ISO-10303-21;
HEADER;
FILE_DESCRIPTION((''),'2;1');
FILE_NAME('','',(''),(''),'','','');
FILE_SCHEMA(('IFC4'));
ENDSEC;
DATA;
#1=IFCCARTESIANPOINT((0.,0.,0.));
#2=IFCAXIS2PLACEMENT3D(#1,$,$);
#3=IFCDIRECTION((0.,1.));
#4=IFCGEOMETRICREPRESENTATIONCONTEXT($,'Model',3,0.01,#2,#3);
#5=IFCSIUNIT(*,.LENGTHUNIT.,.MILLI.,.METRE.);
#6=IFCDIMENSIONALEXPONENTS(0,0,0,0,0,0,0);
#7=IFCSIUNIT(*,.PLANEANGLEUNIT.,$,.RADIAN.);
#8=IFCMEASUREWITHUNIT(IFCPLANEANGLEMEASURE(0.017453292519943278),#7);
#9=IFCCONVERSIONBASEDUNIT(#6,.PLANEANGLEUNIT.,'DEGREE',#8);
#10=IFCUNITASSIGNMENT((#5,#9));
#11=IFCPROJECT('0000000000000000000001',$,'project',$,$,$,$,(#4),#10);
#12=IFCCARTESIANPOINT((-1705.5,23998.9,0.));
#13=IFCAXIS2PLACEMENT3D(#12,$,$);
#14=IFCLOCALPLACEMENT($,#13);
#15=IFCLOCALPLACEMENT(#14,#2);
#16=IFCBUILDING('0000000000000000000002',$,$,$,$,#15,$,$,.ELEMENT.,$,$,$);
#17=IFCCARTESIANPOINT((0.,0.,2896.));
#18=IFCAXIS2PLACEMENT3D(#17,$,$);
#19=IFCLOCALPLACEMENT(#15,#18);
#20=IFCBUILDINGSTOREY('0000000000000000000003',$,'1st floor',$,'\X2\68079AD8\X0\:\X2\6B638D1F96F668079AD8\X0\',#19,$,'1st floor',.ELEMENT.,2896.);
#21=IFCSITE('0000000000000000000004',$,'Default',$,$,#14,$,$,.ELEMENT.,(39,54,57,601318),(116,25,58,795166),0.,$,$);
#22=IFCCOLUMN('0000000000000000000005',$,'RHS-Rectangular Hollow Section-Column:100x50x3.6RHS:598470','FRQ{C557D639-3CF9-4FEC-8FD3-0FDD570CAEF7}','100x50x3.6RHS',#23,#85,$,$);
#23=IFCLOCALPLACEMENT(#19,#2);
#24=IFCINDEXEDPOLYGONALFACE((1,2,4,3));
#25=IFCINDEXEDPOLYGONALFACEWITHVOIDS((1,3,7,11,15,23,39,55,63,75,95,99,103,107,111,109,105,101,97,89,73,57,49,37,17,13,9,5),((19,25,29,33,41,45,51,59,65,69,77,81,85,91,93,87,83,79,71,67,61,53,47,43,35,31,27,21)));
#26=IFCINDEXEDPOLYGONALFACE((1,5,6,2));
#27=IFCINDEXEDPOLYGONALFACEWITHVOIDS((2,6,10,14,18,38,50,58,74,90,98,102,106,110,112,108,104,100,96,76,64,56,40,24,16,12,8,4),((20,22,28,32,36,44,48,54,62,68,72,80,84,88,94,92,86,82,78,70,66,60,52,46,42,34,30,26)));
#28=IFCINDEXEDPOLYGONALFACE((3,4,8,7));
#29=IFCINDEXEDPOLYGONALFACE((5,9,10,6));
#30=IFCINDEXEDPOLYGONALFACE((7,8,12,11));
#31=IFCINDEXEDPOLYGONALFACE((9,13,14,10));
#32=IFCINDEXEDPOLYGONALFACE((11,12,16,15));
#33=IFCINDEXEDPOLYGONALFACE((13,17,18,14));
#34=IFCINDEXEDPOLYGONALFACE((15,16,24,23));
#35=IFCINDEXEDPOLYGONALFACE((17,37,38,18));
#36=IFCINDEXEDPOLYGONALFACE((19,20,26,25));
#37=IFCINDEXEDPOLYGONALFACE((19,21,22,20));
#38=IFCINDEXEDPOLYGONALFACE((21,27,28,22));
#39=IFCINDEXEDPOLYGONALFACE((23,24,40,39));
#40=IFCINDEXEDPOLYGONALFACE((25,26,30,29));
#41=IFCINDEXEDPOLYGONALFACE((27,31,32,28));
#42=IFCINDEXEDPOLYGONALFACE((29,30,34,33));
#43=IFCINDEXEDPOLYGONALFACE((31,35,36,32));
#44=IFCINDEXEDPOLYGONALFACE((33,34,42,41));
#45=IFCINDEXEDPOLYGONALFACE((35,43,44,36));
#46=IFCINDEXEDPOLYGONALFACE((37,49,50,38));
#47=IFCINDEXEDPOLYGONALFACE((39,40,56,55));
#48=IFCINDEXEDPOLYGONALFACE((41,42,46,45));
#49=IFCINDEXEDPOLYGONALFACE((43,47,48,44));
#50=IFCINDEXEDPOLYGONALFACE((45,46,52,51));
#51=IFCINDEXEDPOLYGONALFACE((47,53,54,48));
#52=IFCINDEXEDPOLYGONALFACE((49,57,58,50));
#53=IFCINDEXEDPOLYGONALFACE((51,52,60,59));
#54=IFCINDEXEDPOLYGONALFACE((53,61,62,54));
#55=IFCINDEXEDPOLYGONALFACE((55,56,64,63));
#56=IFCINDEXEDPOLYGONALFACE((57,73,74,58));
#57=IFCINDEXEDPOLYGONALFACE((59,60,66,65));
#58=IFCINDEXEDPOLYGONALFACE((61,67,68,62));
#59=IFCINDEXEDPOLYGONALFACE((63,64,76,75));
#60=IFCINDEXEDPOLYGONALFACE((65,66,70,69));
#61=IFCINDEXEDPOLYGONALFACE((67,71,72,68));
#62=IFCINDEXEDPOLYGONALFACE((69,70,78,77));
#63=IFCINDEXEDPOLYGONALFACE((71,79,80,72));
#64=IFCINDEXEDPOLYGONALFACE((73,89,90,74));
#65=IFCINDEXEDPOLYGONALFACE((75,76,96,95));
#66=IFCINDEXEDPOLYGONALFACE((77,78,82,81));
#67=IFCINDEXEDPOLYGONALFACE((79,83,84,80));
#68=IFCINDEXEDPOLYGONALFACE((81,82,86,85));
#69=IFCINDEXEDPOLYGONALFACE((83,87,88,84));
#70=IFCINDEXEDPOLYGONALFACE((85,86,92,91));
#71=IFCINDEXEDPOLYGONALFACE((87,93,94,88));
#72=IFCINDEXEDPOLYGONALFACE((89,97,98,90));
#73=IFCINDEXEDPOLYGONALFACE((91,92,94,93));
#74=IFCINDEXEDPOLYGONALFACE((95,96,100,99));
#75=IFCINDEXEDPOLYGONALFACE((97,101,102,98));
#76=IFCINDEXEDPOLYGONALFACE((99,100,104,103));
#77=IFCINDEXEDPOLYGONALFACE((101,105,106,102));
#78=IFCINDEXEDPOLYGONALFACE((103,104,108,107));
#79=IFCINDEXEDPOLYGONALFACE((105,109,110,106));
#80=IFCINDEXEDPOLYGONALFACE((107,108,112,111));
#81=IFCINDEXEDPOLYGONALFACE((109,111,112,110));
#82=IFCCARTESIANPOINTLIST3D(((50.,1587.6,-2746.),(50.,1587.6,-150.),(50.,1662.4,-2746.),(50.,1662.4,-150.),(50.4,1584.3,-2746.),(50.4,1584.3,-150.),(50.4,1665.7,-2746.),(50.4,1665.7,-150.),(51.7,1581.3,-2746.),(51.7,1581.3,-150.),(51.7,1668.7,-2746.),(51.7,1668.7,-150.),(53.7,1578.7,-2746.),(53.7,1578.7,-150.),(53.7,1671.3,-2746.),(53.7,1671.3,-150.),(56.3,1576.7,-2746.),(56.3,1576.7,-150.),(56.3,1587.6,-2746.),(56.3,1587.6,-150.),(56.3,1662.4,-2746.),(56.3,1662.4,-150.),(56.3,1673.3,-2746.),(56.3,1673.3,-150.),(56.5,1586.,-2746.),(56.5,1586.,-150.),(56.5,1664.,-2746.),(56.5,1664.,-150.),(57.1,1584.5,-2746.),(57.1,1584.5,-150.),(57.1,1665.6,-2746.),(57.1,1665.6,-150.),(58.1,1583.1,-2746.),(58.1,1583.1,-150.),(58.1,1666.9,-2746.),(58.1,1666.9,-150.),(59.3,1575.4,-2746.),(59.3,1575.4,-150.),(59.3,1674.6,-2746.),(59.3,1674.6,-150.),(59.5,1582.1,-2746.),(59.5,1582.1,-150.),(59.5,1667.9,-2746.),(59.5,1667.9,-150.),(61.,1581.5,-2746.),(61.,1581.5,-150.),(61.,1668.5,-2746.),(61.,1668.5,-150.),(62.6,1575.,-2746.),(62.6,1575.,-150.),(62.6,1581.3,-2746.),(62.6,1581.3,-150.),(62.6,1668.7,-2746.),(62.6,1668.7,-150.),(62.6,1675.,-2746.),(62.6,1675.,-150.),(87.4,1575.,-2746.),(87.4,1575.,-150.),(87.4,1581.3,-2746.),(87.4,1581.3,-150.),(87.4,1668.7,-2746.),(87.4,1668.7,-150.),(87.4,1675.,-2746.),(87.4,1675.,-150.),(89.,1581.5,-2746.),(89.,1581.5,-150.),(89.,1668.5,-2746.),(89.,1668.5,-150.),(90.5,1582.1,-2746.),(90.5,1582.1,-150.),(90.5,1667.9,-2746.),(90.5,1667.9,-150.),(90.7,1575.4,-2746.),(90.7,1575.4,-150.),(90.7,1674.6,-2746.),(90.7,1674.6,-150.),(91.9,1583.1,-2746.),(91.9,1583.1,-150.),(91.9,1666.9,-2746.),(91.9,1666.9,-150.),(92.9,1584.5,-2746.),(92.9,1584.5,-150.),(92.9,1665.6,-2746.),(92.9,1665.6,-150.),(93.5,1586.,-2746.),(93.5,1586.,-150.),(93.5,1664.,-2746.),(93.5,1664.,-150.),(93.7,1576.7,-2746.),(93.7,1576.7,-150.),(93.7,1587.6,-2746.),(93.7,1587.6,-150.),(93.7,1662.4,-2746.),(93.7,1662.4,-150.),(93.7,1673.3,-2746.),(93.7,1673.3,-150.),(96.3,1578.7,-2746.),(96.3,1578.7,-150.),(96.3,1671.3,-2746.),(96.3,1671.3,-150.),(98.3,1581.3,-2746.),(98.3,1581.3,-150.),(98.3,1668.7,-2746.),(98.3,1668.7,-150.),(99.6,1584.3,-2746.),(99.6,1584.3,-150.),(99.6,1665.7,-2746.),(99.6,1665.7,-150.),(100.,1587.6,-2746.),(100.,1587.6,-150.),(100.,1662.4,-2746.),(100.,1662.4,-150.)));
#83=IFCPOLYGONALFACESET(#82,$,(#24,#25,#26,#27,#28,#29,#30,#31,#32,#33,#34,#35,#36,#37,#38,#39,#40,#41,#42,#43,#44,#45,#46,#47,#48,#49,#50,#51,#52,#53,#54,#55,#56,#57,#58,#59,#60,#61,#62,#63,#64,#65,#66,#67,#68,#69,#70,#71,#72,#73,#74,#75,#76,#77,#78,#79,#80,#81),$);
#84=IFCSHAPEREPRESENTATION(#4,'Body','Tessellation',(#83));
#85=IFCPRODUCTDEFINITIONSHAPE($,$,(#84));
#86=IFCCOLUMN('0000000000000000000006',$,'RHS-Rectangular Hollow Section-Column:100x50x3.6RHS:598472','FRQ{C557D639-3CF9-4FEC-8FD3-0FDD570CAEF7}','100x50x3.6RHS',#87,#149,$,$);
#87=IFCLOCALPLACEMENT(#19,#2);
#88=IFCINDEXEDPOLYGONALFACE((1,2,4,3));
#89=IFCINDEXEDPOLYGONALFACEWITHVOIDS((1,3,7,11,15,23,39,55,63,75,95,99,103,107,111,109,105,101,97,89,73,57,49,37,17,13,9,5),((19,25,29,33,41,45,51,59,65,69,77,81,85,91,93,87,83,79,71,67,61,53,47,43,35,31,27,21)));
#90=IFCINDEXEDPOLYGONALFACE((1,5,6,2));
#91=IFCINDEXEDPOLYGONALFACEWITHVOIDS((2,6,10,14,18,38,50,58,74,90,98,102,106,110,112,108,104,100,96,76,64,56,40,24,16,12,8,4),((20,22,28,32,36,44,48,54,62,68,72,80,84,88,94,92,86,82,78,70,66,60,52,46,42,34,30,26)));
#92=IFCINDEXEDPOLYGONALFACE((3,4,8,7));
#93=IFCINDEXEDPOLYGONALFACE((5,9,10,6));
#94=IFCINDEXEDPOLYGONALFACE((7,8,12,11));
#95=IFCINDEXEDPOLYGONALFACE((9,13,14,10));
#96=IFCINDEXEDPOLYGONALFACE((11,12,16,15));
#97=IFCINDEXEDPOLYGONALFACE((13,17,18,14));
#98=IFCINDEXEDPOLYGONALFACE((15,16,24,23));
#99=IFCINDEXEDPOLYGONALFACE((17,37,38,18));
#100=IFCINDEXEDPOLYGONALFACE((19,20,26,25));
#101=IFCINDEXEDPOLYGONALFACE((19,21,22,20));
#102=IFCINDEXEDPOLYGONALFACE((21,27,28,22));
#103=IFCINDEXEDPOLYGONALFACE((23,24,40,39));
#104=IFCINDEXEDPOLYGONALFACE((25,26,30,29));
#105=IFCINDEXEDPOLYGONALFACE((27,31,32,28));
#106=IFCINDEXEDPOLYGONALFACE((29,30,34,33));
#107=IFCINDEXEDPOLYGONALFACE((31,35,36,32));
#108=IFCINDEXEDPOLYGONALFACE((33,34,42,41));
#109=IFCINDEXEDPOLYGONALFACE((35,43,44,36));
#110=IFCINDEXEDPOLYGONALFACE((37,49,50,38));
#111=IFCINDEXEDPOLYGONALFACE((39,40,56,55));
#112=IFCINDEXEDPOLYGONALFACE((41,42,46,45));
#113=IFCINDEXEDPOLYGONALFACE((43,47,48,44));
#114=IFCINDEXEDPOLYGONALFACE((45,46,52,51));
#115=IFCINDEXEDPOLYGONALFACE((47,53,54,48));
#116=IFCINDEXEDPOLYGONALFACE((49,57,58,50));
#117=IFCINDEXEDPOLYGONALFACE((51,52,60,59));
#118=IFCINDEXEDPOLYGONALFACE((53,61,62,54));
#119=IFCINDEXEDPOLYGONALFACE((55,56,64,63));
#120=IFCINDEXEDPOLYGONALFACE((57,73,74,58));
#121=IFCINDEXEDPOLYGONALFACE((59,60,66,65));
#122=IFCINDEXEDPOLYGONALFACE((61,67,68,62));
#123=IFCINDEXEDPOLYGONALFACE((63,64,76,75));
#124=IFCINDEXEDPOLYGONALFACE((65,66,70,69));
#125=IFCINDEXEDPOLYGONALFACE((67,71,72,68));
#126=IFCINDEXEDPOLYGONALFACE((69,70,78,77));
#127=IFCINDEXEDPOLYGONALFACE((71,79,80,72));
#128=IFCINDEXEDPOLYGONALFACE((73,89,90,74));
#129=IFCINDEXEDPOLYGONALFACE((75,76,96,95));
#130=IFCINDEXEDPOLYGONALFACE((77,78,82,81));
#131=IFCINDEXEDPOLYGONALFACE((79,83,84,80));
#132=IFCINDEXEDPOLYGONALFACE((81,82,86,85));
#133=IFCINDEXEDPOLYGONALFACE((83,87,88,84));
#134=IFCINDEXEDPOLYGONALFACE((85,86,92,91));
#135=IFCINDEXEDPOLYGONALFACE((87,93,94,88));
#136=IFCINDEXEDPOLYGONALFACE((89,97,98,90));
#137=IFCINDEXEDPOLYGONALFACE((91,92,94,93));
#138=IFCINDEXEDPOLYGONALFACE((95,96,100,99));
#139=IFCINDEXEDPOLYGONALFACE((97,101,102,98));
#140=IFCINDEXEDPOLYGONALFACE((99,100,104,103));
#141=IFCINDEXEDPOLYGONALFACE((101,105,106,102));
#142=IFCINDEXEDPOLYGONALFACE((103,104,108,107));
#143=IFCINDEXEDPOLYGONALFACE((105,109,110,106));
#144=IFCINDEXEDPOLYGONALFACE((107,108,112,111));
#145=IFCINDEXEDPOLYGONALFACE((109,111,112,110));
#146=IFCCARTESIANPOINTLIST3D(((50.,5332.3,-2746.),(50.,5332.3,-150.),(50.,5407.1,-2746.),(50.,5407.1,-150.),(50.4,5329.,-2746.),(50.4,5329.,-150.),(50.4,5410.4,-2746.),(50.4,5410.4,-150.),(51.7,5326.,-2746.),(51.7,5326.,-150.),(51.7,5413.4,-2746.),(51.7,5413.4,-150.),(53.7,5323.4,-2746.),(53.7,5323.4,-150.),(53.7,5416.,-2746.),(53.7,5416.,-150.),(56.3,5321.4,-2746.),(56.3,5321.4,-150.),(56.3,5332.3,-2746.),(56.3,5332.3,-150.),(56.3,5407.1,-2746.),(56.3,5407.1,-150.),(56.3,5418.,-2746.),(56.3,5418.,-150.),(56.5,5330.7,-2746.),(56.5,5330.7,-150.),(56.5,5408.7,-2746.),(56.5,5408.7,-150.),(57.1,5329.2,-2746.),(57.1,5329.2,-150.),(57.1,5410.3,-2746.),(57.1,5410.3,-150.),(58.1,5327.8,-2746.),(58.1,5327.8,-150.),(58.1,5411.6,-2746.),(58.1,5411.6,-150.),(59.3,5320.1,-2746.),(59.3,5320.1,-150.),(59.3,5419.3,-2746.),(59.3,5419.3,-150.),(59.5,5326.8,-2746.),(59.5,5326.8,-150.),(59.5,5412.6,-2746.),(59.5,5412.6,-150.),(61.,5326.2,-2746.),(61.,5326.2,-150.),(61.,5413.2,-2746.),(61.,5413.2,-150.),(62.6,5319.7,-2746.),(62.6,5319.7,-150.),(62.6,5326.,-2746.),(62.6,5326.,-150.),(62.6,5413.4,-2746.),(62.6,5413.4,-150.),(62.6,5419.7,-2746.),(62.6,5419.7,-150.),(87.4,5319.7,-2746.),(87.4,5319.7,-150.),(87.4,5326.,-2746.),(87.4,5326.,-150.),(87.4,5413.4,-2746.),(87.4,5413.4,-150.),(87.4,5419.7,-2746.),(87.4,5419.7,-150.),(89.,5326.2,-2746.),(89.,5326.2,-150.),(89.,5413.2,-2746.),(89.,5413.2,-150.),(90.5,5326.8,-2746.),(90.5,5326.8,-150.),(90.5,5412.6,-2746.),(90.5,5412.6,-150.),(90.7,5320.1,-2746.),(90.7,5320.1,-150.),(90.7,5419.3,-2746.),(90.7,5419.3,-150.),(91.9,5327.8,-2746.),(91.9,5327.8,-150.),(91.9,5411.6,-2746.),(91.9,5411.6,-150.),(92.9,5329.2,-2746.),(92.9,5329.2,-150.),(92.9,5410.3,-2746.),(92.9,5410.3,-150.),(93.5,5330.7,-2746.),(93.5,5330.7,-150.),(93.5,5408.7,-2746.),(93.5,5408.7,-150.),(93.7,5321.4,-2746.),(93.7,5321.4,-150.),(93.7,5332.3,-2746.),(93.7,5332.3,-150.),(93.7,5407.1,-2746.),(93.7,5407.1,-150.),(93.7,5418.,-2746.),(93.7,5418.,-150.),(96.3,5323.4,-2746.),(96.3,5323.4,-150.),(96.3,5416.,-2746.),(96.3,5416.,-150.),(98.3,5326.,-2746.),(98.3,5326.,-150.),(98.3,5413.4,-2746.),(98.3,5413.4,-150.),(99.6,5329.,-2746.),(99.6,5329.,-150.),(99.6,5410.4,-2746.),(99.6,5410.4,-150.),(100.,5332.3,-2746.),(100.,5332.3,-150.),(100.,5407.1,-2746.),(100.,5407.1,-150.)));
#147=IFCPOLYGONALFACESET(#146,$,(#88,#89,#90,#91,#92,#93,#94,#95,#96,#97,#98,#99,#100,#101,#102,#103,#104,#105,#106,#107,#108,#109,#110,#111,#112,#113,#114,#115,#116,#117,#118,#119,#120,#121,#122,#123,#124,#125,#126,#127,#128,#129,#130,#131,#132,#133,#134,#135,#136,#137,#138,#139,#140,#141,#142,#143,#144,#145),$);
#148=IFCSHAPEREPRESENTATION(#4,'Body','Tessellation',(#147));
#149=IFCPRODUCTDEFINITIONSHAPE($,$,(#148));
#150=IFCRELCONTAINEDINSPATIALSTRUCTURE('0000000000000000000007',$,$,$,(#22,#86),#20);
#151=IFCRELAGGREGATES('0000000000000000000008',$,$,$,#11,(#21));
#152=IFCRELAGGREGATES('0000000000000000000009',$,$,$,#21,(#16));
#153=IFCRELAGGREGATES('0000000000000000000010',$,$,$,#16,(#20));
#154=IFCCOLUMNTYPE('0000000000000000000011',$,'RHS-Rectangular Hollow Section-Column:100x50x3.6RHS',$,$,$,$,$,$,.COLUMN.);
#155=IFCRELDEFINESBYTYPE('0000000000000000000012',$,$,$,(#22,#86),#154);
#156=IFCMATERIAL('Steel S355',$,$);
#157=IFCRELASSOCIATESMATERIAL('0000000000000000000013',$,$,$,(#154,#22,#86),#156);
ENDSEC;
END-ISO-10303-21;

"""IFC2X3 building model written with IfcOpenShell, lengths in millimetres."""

from ifc_helpers import new_model, entity, si_unit, converted_unit, point, direction, frame, frame_2d, origin, origin_2d, place, context, project, spatial, circle_curve, line_curve, trimmed, segment, composite_curve, hollow_rectangle, outline, extrude, clip, halfspace, material, type_object, element, save


model = new_model("IFC2X3")

# Units and contexts
model_context = context("Model", 3, precision=0.01, world=origin(), true_north=direction((0.0, 1.0)))
ifc_project = project(units=[si_unit("LENGTHUNIT", "METRE", prefix="MILLI"), converted_unit("PLANEANGLEUNIT", "DEGREE", entity("IfcPlaneAngleMeasure", 0.017453292519943278), si_unit("PLANEANGLEUNIT", "RADIAN"), dimensions=[0, 0, 0, 0, 0, 0, 0])], contexts=[model_context])

# Site, building, storey
site_placement = place(None, frame((-1705.5, 23998.9, 0.0)))
site = spatial("IfcSite", under=ifc_project, at=site_placement, Name="Default", CompositionType="ELEMENT", RefLatitude=(39, 54, 57, 601318), RefLongitude=(116, 25, 58, 795166), RefElevation=0.0)
building_placement = place(site_placement, origin())
building = spatial("IfcBuilding", under=site, at=building_placement, CompositionType="ELEMENT")
storey_placement = place(building_placement, frame((0.0, 0.0, 2896.0)))
storey = spatial("IfcBuildingStorey", under=building, at=storey_placement, Name="1st floor", ObjectType="标高:正负零标高", LongName="1st floor", CompositionType="ELEMENT", Elevation=2896.0)

# Columns, openings
ifc_material_1 = material(Name="Steel S355")
column_type_1 = type_object("IfcColumnType", Name="RHS-Rectangular Hollow Section-Column:100x50x3.6RHS", PredefinedType="COLUMN", material=ifc_material_1)
column_1_placement = place(storey_placement, frame((75.0, 1625.0, -19.1)))
column_1 = element("IfcColumn", 1, at=column_1_placement, inside=storey, type_object=column_type_1, material=ifc_material_1, Name="RHS-Rectangular Hollow Section-Column:100x50x3.6RHS:598470", Description="FRQ{C557D639-3CF9-4FEC-8FD3-0FDD570CAEF7}", ObjectType="100x50x3.6RHS", context=model_context, shape_type="Clipping", body=[
    clip(clip(extrude(hollow_rectangle(XDim=50.0, YDim=100.0, WallThickness=6.3, InnerFilletRadius=6.3, OuterFilletRadius=12.6, at=origin_2d()), origin(), (0.0, 0.0, -1.0), 2782.8), halfspace(frame((-75.0, -1625.0, -2726.9), z_axis=(0.0, 0.0, 1.0), x_axis=(1.0, 0.0, 0.0)), True)), halfspace(frame((-75.0, -1625.0, -55.9), z_axis=(0.0, 0.0, -1.0), x_axis=(-1.0, 0.0, 0.0)), True)),
])
opening_1_placement = place(column_1_placement, frame((0.0, -150.1, -130.9), z_axis=(0.0, 1.0, 0.0), x_axis=(-1.0, 0.0, 0.0)))
element("IfcOpeningElement", 2, at=opening_1_placement, cuts=column_1, ObjectType="Opening", context=model_context, shape_type="SweptSolid", body=[
    extrude(outline(composite_curve([segment(trimmed(circle_curve(frame_2d((43.0, 32.0), x_axis=(1.0, 0.0)), 32.0), [point((43.0, 0.0))], [point((75.0, 32.0))], True, "CARTESIAN"), True, "CONTINUOUS"), segment(trimmed(line_curve((75.0, 32.0), (0.0, 1.0), 86.0), [point((75.0, 32.0))], [point((75.0, 118.0))], True, "CARTESIAN"), True, "CONTINUOUS"), segment(trimmed(circle_curve(frame_2d((43.0, 118.0), x_axis=(1.0, 0.0)), 32.0), [point((75.0, 118.0))], [point((43.0, 150.0))], True, "CARTESIAN"), True, "CONTINUOUS"), segment(trimmed(line_curve((43.0, 150.0), (-1.0, 0.0), 86.0), [point((43.0, 150.0))], [point((-43.0, 150.0))], True, "CARTESIAN"), True, "CONTINUOUS"), segment(trimmed(circle_curve(frame_2d((-43.0, 118.0), x_axis=(1.0, 0.0)), 32.0), [point((-43.0, 150.0))], [point((-75.0, 118.0))], True, "CARTESIAN"), True, "CONTINUOUS"), segment(trimmed(line_curve((-75.0, 118.0), (0.0, -1.0), 86.0), [point((-75.0, 118.0))], [point((-75.0, 32.0))], True, "CARTESIAN"), True, "CONTINUOUS"), segment(trimmed(circle_curve(frame_2d((-43.0, 32.0), x_axis=(1.0, 0.0)), 32.0), [point((-75.0, 32.0))], [point((-43.0, 0.0))], True, "CARTESIAN"), True, "CONTINUOUS"), segment(trimmed(line_curve((-43.0, 0.0), (1.0, 0.0), 86.0), [point((-43.0, 0.0))], [point((43.0, 0.0))], True, "CARTESIAN"), True, "CONTINUOUS")], self_intersect="UNKNOWN")), origin(), (0.0, 0.0, 1.0), 300.2),
])
column_2_placement = place(storey_placement, frame((75.0, 5369.7, -19.1)))
column_2 = element("IfcColumn", 3, at=column_2_placement, inside=storey, type_object=column_type_1, material=ifc_material_1, Name="RHS-Rectangular Hollow Section-Column:100x50x3.6RHS:598472", Description="FRQ{C557D639-3CF9-4FEC-8FD3-0FDD570CAEF7}", ObjectType="100x50x3.6RHS", context=model_context, shape_type="Clipping", body=[
    clip(clip(extrude(hollow_rectangle(XDim=50.0, YDim=100.0, WallThickness=6.3, InnerFilletRadius=6.3, OuterFilletRadius=12.6, at=origin_2d()), origin(), (0.0, 0.0, -1.0), 2782.8), halfspace(frame((-75.0, -5369.7, -55.9), z_axis=(0.0, 0.0, -1.0), x_axis=(-1.0, 0.0, 0.0)), True)), halfspace(frame((-75.0, -5369.7, -2726.9), z_axis=(0.0, 0.0, 1.0), x_axis=(1.0, 0.0, 0.0)), True)),
])
opening_2_placement = place(column_2_placement, frame((0.0, -150.1, -130.9), z_axis=(0.0, 1.0, 0.0), x_axis=(-1.0, 0.0, 0.0)))
element("IfcOpeningElement", 4, at=opening_2_placement, cuts=column_2, ObjectType="Opening", context=model_context, shape_type="SweptSolid", body=[
    extrude(outline(composite_curve([segment(trimmed(circle_curve(frame_2d((43.0, 32.0), x_axis=(1.0, 0.0)), 32.0), [point((43.0, 0.0))], [point((75.0, 32.0))], True, "CARTESIAN"), True, "CONTINUOUS"), segment(trimmed(line_curve((75.0, 32.0), (0.0, 1.0), 86.0), [point((75.0, 32.0))], [point((75.0, 118.0))], True, "CARTESIAN"), True, "CONTINUOUS"), segment(trimmed(circle_curve(frame_2d((43.0, 118.0), x_axis=(1.0, 0.0)), 32.0), [point((75.0, 118.0))], [point((43.0, 150.0))], True, "CARTESIAN"), True, "CONTINUOUS"), segment(trimmed(line_curve((43.0, 150.0), (-1.0, 0.0), 86.0), [point((43.0, 150.0))], [point((-43.0, 150.0))], True, "CARTESIAN"), True, "CONTINUOUS"), segment(trimmed(circle_curve(frame_2d((-43.0, 118.0), x_axis=(1.0, 0.0)), 32.0), [point((-43.0, 150.0))], [point((-75.0, 118.0))], True, "CARTESIAN"), True, "CONTINUOUS"), segment(trimmed(line_curve((-75.0, 118.0), (0.0, -1.0), 86.0), [point((-75.0, 118.0))], [point((-75.0, 32.0))], True, "CARTESIAN"), True, "CONTINUOUS"), segment(trimmed(circle_curve(frame_2d((-43.0, 32.0), x_axis=(1.0, 0.0)), 32.0), [point((-75.0, 32.0))], [point((-43.0, 0.0))], True, "CARTESIAN"), True, "CONTINUOUS"), segment(trimmed(line_curve((-43.0, 0.0), (1.0, 0.0), 86.0), [point((-43.0, 0.0))], [point((43.0, 0.0))], True, "CARTESIAN"), True, "CONTINUOUS")], self_intersect="UNKNOWN")), origin(), (0.0, 0.0, 1.0), 300.2),
])

save(model, "model.ifc")
